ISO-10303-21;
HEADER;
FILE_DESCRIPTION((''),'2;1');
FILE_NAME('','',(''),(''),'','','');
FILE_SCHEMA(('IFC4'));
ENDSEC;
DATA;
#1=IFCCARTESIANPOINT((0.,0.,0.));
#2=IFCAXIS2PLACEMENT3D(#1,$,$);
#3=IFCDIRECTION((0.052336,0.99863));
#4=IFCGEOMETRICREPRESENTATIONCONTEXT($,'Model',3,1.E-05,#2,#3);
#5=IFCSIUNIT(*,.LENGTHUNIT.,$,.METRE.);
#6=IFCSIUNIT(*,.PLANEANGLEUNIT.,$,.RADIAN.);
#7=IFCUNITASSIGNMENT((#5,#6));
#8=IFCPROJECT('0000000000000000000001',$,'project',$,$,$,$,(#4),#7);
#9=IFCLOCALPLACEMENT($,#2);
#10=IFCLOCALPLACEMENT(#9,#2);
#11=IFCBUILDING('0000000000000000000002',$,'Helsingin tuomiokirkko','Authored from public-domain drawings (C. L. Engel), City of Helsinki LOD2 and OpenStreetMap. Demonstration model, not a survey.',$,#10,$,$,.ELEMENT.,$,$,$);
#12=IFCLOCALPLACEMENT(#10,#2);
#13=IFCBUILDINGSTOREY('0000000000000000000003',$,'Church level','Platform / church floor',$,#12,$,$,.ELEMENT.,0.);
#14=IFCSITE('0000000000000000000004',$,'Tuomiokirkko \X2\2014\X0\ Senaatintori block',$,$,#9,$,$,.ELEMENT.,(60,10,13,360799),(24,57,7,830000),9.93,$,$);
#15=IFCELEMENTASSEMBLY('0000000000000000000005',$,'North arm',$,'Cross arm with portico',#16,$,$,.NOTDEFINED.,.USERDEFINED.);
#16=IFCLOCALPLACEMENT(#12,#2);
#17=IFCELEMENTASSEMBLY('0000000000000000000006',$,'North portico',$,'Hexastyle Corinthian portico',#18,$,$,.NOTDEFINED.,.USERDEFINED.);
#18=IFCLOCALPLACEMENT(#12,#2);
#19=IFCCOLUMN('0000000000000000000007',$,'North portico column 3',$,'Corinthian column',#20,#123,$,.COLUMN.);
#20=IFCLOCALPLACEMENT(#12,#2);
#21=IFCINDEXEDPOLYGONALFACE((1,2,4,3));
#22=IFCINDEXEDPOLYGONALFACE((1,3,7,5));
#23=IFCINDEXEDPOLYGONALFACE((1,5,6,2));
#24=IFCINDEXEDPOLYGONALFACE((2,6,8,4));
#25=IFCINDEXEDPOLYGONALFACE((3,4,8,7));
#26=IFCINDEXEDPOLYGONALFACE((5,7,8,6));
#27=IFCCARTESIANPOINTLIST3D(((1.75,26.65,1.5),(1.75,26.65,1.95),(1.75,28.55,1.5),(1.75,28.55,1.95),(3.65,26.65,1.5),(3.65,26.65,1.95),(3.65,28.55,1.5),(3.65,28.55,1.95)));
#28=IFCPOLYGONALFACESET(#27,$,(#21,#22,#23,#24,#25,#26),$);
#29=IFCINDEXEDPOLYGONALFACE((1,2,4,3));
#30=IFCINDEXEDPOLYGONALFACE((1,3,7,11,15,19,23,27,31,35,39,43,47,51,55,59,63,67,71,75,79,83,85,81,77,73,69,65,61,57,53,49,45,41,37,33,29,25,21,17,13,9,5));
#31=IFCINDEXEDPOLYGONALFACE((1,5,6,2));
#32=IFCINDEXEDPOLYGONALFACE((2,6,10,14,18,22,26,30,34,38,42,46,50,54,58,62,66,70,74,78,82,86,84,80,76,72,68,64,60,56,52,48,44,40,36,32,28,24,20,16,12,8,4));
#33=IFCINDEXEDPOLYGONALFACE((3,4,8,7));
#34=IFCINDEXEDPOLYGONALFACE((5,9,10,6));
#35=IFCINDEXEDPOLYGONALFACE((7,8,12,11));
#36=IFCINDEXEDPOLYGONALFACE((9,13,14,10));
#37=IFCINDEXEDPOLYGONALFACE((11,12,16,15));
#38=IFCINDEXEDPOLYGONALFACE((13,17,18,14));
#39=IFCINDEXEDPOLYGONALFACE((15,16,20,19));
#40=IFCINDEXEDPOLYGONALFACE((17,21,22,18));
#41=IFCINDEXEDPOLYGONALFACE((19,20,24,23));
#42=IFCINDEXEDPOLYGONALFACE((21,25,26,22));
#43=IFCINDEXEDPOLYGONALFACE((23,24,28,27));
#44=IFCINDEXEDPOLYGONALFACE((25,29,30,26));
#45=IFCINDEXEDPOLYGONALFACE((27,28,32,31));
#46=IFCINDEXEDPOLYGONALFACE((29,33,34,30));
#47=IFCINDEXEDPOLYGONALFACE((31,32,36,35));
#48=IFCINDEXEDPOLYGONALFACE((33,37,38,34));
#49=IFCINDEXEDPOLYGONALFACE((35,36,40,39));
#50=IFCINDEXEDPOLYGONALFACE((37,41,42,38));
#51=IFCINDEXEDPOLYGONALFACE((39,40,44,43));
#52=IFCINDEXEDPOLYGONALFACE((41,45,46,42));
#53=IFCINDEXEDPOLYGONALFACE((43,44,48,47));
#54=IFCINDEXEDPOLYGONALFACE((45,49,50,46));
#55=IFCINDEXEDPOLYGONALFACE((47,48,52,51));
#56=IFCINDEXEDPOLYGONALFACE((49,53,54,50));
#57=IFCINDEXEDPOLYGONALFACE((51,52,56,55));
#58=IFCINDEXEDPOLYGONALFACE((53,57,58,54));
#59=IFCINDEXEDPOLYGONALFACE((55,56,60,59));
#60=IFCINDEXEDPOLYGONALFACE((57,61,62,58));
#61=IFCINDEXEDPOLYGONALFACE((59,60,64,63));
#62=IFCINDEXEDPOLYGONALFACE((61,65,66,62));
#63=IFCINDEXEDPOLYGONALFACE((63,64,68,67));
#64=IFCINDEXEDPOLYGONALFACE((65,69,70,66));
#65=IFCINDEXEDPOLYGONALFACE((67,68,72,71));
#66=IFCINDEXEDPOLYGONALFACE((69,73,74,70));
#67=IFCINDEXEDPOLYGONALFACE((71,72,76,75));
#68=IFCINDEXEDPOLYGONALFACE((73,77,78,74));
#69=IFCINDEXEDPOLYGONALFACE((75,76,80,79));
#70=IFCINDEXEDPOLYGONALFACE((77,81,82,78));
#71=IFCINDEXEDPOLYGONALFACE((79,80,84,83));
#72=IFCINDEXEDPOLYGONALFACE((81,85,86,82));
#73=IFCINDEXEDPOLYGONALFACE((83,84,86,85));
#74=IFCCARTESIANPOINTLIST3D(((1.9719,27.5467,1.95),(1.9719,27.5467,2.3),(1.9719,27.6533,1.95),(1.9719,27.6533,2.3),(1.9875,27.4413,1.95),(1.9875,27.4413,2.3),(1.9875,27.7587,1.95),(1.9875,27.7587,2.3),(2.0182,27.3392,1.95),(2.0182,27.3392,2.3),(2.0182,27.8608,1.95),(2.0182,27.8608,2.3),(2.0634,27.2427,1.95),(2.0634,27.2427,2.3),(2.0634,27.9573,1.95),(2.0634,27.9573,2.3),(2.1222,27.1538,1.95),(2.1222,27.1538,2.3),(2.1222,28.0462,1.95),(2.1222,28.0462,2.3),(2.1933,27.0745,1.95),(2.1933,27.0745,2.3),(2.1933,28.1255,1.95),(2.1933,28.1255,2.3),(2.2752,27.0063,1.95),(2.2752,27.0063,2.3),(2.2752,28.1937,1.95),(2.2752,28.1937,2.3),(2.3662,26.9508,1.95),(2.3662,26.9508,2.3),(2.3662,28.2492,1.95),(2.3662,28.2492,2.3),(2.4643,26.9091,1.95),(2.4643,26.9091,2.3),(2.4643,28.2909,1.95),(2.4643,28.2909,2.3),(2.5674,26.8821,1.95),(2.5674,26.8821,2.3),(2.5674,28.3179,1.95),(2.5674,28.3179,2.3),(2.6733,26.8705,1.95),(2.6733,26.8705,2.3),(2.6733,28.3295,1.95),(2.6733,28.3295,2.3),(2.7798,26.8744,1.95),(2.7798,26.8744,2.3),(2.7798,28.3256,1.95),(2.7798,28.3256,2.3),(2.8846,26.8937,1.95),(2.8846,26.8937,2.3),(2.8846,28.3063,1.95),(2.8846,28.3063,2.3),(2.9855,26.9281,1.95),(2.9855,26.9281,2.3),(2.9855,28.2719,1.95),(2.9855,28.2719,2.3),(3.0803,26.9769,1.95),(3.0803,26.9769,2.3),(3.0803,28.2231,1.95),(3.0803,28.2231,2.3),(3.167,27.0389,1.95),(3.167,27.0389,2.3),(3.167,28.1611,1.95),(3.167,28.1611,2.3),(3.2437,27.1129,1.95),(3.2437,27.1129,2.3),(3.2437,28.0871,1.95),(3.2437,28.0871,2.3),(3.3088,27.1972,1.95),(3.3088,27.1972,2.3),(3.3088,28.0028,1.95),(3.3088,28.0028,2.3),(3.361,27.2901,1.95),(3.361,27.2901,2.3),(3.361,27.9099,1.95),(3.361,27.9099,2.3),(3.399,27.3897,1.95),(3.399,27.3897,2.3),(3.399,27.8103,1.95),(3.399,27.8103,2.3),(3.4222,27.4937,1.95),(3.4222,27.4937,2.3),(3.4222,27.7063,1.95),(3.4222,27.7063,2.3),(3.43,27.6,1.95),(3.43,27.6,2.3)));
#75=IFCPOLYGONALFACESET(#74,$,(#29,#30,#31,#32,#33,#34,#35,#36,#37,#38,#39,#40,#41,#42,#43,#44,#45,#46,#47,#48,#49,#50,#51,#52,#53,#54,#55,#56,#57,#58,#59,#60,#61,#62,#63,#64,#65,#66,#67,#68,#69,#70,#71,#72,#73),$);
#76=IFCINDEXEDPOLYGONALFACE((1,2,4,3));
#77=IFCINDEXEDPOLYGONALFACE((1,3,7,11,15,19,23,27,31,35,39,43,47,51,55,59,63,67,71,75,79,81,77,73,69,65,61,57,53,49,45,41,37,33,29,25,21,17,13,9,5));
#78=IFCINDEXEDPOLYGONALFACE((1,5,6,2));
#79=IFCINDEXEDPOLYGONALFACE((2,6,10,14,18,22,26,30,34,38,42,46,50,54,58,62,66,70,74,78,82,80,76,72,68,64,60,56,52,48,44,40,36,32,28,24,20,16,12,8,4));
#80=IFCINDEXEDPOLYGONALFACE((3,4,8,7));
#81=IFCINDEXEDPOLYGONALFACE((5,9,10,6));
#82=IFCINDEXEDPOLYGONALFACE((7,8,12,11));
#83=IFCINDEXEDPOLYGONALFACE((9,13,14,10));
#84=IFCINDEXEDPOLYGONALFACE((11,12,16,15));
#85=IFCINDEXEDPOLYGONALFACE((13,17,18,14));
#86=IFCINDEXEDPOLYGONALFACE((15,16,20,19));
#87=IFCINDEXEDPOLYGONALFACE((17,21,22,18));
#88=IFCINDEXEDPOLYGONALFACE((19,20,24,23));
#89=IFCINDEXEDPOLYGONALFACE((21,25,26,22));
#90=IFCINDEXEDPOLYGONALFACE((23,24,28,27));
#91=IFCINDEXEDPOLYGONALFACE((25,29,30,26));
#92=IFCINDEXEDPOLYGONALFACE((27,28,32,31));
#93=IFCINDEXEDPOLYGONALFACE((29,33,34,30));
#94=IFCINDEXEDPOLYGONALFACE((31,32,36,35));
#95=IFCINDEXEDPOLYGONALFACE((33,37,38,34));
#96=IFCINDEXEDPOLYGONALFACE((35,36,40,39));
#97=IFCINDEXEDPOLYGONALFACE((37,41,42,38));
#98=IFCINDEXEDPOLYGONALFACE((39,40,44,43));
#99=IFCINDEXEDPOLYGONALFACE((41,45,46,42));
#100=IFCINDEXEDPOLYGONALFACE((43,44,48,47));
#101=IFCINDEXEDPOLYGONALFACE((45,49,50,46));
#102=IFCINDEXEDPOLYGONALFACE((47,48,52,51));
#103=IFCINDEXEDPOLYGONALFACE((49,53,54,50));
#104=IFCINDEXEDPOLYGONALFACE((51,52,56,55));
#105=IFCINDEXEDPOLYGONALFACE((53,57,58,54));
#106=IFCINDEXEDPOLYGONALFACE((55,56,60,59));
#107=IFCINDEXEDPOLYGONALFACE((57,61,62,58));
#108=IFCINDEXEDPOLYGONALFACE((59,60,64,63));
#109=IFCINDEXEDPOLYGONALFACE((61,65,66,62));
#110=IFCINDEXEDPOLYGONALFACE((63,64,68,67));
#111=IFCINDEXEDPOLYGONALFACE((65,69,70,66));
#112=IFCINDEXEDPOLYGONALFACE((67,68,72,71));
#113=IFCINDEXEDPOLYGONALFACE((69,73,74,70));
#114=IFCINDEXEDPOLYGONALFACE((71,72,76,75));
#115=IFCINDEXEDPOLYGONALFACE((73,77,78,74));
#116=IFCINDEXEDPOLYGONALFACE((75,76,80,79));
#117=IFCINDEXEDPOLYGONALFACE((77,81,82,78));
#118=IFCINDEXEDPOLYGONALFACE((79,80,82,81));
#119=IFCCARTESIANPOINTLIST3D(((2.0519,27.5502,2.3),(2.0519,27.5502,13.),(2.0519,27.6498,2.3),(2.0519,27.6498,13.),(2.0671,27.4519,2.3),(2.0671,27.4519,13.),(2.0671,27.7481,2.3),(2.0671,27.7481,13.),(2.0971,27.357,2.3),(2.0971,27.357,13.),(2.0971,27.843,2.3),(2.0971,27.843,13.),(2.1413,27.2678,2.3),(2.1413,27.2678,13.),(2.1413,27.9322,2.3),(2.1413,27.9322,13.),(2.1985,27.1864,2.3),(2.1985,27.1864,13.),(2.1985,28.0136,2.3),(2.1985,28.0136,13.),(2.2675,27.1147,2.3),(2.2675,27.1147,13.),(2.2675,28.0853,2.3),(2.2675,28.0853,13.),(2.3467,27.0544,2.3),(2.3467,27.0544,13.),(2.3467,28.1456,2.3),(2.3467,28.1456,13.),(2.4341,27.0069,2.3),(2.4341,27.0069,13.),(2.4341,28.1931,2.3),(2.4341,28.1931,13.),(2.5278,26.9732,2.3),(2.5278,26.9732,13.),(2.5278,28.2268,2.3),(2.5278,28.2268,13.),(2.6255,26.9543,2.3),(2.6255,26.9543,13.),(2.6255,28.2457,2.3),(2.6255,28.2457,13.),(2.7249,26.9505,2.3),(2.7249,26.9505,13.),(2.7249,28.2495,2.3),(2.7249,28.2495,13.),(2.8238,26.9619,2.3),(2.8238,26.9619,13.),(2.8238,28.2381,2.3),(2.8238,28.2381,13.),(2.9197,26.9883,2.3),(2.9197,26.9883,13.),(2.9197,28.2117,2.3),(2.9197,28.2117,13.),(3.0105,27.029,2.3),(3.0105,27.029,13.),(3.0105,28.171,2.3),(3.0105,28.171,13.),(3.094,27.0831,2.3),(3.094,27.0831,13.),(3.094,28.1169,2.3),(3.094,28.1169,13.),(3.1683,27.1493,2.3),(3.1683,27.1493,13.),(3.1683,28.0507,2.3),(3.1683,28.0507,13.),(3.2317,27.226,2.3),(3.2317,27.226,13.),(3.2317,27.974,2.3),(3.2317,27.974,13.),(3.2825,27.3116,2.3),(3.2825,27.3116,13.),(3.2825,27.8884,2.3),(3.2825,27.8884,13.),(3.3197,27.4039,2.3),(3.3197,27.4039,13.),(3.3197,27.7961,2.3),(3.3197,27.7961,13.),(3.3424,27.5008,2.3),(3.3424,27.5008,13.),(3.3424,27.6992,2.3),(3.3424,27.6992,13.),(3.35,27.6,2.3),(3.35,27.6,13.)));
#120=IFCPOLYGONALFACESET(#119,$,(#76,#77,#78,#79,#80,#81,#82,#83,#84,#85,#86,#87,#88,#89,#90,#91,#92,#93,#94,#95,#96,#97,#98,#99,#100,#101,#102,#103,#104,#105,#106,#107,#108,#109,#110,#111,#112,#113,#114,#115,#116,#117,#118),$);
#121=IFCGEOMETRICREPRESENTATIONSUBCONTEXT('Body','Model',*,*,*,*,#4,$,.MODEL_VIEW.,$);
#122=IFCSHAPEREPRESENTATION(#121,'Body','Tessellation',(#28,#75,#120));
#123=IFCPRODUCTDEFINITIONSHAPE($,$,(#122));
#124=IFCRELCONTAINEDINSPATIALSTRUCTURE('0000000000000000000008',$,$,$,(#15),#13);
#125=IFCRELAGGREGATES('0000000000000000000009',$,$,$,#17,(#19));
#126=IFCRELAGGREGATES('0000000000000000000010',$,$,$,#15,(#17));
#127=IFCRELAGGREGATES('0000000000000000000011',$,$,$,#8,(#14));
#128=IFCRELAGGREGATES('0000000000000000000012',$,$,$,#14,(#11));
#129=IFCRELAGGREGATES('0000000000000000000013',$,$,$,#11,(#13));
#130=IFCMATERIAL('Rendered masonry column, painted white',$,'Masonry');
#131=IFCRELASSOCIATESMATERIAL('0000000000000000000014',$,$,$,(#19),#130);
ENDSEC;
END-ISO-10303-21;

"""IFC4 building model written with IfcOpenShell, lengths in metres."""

from ifc_helpers import new_model, si_unit, direction, frame, origin, origin_2d_with_axis, place, context, subcontext, project, spatial, rectangle, circle, extrude, material, element, aggregate, save


model = new_model("IFC4")

# Units and contexts
model_context = context("Model", 3, precision=1e-05, world=origin(), true_north=direction((0.052336, 0.99863)))
body_context = subcontext(model_context, "Body", "Model", "MODEL_VIEW")
ifc_project = project(units=[si_unit("LENGTHUNIT", "METRE"), si_unit("PLANEANGLEUNIT", "RADIAN")], contexts=[model_context])

# Site, building, storey
site_placement = place(None, origin())
site = spatial("IfcSite", under=ifc_project, at=site_placement, Name="Tuomiokirkko — Senaatintori block", CompositionType="ELEMENT", RefLatitude=(60, 10, 13, 360799), RefLongitude=(24, 57, 7, 830000), RefElevation=9.93)
building_placement = place(site_placement, origin())
building = spatial("IfcBuilding", under=site, at=building_placement, Name="Helsingin tuomiokirkko", Description="Authored from public-domain drawings (C. L. Engel), City of Helsinki LOD2 and OpenStreetMap. Demonstration model, not a survey.", CompositionType="ELEMENT")
storey_placement = place(building_placement, origin())
storey = spatial("IfcBuildingStorey", under=building, at=storey_placement, Name="Church level", Description="Platform / church floor", CompositionType="ELEMENT", Elevation=0.0)

# Element assemblies, column
ifc_material_1 = material(Name="Rendered masonry column, painted white", Category="Masonry")
assembly_1_placement = place(building_placement, origin())
assembly_1 = element("IfcElementAssembly", 1, at=assembly_1_placement, inside=storey, Name="North arm", ObjectType="Cross arm with portico", AssemblyPlace="NOTDEFINED", PredefinedType="USERDEFINED")
assembly_2_placement = place(building_placement, origin())
assembly_2 = element("IfcElementAssembly", 2, at=assembly_2_placement, Name="North portico", ObjectType="Hexastyle Corinthian portico", AssemblyPlace="NOTDEFINED", PredefinedType="USERDEFINED")
column_1_placement = place(building_placement, origin())
column_1 = element("IfcColumn", 3, at=column_1_placement, material=ifc_material_1, Name="North portico column 3", ObjectType="Corinthian column", PredefinedType="COLUMN", context=body_context, shape_type="SweptSolid", body=[
    extrude(rectangle(XDim=1.9, YDim=1.9, at=origin_2d_with_axis()), frame((2.7, 27.6, 1.5)), (0.0, 0.0, 1.0), 0.45),
    extrude(circle(Radius=0.73, at=origin_2d_with_axis()), frame((2.7, 27.6, 1.95)), (0.0, 0.0, 1.0), 0.35),
    extrude(circle(Radius=0.65, at=origin_2d_with_axis()), frame((2.7, 27.6, 2.3)), (0.0, 0.0, 1.0), 10.7),
])

aggregate(assembly_2, [column_1])

aggregate(assembly_1, [assembly_2])

save(model, "model.ifc")
